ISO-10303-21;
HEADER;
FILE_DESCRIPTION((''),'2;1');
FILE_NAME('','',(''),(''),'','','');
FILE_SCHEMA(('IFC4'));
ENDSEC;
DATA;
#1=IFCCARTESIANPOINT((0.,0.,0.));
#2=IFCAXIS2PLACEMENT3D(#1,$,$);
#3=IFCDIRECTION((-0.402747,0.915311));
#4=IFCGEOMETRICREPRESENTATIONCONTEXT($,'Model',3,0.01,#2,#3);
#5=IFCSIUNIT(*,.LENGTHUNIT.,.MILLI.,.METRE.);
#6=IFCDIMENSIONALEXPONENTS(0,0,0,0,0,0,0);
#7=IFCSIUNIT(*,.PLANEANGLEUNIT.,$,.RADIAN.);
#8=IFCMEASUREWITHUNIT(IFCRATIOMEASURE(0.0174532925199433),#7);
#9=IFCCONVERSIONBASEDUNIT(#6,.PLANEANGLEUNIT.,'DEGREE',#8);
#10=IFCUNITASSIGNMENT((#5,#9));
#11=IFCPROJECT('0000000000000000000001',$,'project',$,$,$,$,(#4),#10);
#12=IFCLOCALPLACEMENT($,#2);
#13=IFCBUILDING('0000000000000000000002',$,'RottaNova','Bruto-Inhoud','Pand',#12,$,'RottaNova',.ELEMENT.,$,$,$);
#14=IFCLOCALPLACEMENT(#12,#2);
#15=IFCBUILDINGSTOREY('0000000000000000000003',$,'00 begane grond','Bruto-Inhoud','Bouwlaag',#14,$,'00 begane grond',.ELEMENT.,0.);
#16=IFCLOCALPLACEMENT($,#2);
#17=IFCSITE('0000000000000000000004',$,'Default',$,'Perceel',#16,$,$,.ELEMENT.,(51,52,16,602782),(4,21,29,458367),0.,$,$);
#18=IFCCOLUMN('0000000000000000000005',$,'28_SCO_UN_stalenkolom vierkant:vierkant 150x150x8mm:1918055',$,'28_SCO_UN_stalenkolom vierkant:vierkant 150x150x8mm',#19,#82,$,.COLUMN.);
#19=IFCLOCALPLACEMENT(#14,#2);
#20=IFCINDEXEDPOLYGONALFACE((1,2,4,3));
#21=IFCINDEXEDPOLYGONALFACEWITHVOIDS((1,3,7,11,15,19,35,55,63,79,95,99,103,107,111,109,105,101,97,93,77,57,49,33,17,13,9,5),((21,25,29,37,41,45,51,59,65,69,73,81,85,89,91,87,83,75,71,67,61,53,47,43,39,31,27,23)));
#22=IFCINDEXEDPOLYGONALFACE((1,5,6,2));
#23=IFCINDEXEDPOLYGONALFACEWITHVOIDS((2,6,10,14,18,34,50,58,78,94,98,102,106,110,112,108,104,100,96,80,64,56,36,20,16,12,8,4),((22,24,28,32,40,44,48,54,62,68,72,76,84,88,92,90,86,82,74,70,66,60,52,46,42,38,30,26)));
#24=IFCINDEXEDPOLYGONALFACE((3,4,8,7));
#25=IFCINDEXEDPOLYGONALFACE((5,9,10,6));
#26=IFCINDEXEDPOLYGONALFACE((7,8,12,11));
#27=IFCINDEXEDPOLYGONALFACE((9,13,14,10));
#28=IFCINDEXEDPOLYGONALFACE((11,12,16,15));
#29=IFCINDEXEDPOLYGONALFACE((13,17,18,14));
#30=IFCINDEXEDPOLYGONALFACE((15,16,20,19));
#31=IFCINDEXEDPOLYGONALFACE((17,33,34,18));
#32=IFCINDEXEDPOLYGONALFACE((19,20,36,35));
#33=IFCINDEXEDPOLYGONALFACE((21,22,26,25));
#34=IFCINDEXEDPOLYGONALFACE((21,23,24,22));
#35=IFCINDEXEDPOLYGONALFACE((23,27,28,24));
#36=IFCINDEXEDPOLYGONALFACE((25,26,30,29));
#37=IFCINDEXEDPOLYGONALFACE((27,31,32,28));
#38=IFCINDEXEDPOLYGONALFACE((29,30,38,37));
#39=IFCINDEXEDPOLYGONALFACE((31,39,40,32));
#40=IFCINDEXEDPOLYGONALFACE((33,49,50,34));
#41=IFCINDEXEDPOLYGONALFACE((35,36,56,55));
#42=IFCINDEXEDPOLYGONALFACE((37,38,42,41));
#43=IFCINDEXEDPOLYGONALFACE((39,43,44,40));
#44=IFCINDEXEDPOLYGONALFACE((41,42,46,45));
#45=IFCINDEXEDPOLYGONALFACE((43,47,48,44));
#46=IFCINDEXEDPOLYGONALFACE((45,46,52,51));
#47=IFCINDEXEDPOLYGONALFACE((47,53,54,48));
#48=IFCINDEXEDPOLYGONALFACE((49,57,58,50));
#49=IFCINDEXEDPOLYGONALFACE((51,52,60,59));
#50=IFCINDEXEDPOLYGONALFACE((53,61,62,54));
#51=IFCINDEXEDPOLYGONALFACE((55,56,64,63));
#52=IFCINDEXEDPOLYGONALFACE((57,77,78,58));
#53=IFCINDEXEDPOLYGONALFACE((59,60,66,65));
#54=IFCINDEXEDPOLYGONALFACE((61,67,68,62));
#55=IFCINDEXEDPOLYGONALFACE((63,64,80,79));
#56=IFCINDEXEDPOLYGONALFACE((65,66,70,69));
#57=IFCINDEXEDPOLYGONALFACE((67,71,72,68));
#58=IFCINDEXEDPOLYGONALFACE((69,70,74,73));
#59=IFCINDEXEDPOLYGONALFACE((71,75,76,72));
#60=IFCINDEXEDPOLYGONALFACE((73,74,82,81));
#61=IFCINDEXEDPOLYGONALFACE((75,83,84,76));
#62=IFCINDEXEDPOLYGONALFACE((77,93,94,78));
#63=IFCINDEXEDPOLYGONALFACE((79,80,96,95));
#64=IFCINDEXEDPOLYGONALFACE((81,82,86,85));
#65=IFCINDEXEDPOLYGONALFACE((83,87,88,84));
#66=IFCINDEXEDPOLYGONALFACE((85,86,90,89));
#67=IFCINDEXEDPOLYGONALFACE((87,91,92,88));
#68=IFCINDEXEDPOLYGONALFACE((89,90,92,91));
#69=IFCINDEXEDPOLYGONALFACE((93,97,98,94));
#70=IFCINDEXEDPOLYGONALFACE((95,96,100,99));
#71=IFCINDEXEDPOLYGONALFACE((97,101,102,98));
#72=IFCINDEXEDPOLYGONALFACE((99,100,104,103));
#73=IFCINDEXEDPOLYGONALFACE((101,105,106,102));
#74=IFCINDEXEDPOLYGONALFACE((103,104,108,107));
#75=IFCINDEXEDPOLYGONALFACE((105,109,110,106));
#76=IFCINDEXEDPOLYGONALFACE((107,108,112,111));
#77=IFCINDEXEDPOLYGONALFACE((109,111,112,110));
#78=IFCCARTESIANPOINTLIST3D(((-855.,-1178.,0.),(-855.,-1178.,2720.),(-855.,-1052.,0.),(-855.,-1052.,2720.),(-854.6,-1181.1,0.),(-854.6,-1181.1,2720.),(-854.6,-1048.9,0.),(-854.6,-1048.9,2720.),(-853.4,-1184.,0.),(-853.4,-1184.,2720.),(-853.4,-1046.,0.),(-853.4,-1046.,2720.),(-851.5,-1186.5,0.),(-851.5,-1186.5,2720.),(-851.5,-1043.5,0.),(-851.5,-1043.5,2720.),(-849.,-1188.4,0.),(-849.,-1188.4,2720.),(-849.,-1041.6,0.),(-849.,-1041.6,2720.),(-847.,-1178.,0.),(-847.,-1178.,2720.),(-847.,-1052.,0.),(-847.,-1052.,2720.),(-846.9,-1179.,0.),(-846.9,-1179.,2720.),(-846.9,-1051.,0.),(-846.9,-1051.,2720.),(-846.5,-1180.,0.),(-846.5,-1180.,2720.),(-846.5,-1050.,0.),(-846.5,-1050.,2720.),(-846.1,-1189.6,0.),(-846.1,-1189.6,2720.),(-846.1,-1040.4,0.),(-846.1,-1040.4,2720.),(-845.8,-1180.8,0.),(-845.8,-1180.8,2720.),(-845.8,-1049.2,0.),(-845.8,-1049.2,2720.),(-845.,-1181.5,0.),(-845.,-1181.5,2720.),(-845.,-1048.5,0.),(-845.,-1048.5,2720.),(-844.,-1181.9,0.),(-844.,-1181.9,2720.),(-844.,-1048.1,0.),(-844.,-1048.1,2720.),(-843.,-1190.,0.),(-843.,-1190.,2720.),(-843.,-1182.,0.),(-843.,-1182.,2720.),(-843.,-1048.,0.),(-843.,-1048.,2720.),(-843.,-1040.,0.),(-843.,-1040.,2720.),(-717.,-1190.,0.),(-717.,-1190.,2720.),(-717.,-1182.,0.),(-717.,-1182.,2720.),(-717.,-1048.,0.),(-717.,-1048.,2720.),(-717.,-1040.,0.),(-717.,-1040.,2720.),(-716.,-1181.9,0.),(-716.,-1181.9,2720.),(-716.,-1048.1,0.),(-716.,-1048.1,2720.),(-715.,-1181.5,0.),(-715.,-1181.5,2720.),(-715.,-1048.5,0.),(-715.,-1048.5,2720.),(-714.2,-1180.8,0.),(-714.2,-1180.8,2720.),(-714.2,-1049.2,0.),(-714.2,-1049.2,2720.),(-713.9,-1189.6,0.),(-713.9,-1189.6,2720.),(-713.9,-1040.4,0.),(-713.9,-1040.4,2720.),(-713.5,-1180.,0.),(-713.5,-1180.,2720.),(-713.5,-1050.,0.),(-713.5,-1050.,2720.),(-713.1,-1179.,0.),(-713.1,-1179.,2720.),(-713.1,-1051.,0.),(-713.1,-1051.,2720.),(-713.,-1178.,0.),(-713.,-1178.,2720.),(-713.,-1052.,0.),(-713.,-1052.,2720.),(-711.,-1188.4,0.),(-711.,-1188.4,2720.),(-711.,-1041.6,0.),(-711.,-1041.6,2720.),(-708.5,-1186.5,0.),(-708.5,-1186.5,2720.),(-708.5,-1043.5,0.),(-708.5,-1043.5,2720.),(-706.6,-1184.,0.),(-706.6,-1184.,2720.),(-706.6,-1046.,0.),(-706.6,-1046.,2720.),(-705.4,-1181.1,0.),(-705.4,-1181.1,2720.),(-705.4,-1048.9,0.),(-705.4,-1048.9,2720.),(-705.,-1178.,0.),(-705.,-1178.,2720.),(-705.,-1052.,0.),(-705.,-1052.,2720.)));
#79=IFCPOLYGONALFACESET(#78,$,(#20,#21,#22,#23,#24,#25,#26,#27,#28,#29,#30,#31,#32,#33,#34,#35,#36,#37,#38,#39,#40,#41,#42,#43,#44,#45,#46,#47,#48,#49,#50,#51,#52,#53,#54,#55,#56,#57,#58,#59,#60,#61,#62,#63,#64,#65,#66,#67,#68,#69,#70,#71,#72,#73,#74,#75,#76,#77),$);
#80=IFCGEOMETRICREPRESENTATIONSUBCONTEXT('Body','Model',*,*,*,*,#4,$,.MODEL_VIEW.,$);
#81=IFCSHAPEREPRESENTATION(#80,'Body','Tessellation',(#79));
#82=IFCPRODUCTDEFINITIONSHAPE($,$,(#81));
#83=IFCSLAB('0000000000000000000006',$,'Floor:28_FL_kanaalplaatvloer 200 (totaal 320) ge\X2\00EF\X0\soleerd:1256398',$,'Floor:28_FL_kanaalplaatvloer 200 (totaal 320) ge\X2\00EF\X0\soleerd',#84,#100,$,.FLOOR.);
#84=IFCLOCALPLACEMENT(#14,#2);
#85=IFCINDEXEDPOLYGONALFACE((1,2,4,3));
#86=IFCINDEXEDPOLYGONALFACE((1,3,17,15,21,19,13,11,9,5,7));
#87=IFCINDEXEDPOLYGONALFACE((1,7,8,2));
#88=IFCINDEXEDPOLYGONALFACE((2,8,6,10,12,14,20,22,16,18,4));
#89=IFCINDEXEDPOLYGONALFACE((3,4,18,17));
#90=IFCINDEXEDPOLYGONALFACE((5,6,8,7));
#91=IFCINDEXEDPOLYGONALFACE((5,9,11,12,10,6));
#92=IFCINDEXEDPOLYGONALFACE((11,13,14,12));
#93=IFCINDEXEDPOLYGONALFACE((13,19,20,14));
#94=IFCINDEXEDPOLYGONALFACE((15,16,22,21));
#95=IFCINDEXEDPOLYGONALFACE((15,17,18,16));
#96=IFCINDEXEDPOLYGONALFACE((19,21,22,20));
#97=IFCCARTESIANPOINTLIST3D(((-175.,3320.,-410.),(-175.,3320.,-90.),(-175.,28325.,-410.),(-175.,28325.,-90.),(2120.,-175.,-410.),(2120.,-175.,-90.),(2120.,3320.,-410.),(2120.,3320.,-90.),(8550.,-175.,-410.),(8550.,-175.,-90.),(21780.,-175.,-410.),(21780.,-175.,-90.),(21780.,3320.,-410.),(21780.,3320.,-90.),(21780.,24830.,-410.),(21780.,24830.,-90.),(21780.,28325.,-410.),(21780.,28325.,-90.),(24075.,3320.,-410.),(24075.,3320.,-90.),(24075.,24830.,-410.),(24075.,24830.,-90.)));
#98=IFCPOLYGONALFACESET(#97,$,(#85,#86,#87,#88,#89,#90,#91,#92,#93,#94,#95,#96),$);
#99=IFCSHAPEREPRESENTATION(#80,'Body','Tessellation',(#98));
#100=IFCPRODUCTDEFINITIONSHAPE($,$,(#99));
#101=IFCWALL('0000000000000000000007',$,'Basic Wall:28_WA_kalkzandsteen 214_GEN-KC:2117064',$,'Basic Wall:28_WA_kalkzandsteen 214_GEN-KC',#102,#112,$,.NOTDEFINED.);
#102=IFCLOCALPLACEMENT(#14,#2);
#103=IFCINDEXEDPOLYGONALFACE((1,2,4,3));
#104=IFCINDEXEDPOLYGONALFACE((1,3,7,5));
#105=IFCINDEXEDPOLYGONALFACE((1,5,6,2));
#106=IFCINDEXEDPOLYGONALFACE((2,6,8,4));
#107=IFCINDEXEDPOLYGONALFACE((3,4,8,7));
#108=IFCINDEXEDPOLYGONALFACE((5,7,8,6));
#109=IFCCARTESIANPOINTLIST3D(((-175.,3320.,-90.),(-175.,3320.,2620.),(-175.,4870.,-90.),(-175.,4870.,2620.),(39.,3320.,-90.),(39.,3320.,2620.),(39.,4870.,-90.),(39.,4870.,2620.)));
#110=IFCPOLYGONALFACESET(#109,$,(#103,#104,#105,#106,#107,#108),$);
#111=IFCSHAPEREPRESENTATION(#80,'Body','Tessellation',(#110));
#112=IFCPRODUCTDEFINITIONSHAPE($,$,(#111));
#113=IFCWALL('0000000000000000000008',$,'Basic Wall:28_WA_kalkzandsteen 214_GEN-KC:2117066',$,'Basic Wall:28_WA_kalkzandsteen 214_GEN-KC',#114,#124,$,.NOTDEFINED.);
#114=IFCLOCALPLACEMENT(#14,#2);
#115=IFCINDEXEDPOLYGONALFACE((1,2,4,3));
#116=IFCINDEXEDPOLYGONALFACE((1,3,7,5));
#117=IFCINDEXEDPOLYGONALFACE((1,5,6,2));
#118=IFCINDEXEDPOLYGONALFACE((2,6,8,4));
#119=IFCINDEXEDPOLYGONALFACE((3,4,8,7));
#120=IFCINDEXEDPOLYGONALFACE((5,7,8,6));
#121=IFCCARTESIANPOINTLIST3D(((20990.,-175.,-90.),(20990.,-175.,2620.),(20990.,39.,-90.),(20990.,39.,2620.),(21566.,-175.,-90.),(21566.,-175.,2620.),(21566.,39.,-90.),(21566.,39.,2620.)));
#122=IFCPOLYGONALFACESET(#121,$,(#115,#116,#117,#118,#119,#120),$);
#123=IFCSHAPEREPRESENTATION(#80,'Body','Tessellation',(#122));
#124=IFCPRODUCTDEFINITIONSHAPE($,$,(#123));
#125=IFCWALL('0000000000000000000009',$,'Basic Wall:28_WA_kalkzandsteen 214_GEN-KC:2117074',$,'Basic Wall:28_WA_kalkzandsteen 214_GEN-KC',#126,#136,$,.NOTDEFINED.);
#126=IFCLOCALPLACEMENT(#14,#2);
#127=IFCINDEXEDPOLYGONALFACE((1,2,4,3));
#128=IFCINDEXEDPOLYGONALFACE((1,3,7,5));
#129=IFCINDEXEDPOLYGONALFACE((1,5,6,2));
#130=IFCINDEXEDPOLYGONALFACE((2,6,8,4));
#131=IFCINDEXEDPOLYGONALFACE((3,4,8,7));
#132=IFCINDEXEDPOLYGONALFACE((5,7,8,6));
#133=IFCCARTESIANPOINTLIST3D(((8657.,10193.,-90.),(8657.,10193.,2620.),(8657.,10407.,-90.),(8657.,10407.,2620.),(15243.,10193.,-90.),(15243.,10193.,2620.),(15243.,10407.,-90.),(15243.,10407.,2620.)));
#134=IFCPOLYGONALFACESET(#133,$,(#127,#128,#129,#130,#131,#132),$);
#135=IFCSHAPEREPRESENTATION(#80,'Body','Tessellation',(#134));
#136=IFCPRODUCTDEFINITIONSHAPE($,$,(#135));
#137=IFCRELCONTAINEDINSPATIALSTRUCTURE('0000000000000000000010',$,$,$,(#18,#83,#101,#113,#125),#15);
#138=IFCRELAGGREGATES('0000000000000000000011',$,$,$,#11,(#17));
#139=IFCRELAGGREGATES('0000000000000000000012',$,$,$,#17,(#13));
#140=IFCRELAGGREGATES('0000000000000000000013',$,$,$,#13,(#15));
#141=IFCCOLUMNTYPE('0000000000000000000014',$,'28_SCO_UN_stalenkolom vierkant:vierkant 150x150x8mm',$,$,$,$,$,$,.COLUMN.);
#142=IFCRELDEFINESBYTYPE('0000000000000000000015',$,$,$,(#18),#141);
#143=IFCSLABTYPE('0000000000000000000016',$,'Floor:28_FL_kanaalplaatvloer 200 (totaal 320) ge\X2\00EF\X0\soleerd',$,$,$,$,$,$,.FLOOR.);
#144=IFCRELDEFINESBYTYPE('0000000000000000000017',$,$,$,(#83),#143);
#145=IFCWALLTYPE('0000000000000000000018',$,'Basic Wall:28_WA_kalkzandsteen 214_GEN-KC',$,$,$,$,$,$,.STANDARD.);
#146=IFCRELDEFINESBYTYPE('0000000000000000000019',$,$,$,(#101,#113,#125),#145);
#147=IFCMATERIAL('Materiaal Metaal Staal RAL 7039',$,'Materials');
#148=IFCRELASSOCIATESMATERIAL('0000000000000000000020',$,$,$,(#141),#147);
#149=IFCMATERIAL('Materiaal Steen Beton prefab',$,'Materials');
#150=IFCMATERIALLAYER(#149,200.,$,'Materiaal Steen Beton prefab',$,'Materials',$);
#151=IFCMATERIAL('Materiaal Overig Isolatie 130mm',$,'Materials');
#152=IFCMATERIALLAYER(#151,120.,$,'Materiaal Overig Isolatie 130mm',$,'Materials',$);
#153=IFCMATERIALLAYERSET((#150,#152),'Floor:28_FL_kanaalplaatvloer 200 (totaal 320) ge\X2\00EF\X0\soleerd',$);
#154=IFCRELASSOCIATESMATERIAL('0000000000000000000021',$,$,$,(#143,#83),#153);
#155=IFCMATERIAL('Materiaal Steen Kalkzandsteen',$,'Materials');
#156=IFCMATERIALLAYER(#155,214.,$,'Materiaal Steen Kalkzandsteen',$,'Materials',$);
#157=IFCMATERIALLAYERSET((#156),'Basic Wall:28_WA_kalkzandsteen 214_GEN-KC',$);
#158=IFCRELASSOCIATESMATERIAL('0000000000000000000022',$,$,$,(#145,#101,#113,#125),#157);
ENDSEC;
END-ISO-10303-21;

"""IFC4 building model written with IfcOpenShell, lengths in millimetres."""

from ifc_helpers import new_model, entity, si_unit, converted_unit, direction, frame, frame_2d, origin, place, context, subcontext, project, spatial, polyline, circle_curve, parameter, trimmed, segment, composite_curve, rectangle, outline, extrude, source, transform, mapped, material, layer, layer_set, layer_usage, material_profile, profile_set, type_object, type_shapes, element, save


model = new_model("IFC4")

# Units and contexts
model_context = context("Model", 3, precision=0.01, world=origin(), true_north=direction((-0.402747, 0.915311)))
body_context = subcontext(model_context, "Body", "Model", "MODEL_VIEW")
ifc_project = project(units=[si_unit("LENGTHUNIT", "METRE", prefix="MILLI"), converted_unit("PLANEANGLEUNIT", "DEGREE", entity("IfcRatioMeasure", 0.0174532925199433), si_unit("PLANEANGLEUNIT", "RADIAN"), dimensions=[0, 0, 0, 0, 0, 0, 0])], contexts=[model_context])

# Site, building, storey
site_placement = place(None, origin())
site = spatial("IfcSite", under=ifc_project, at=site_placement, Name="Default", ObjectType="Perceel", CompositionType="ELEMENT", RefLatitude=(51, 52, 16, 602782), RefLongitude=(4, 21, 29, 458367), RefElevation=0.0)
building_placement = place(None, origin())
building = spatial("IfcBuilding", under=site, at=building_placement, Name="RottaNova", Description="Bruto-Inhoud", ObjectType="Pand", LongName="RottaNova", CompositionType="ELEMENT")
storey_placement = place(building_placement, origin())
storey = spatial("IfcBuildingStorey", under=building, at=storey_placement, Name="00 begane grond", Description="Bruto-Inhoud", ObjectType="Bouwlaag", LongName="00 begane grond", CompositionType="ELEMENT", Elevation=0.0)

# Column
ifc_material_1 = material(Name="Materiaal Metaal Staal RAL 7039", Category="Materials")
ifc_material_profile = material_profile(ifc_material_1, outline(composite_curve([segment(trimmed(circle_curve(frame_2d((63.0, -63.0), x_axis=(1.0, 0.0)), 12.0), [parameter(270.0)], [parameter(360.0)], True, "PARAMETER"), True, "CONTINUOUS"), segment(polyline([(75.0, -63.0), (75.0, 63.0)]), True, "CONTINUOUS"), segment(trimmed(circle_curve(frame_2d((63.0, 63.0), x_axis=(1.0, 0.0)), 12.0), [parameter(360.0)], [parameter(90.0)], True, "PARAMETER"), True, "CONTINUOUS"), segment(polyline([(63.0, 75.0), (-63.0, 75.0)]), True, "CONTINUOUS"), segment(trimmed(circle_curve(frame_2d((-63.0, 63.0), x_axis=(1.0, 0.0)), 12.0), [parameter(90.0)], [parameter(180.0)], True, "PARAMETER"), True, "CONTINUOUS"), segment(polyline([(-75.0, 63.0), (-75.0, -63.0)]), True, "CONTINUOUS"), segment(trimmed(circle_curve(frame_2d((-63.0, -63.0), x_axis=(1.0, 0.0)), 12.0), [parameter(180.0)], [parameter(270.0)], True, "PARAMETER"), True, "CONTINUOUS"), segment(polyline([(-63.0, -75.0), (63.0, -75.0)]), True, "CONTINUOUS")], self_intersect=False), holes=[composite_curve([segment(polyline([(-67.0, -63.0), (-67.0, 63.0)]), True, "CONTINUOUS"), segment(trimmed(circle_curve(frame_2d((-63.0, 63.0), x_axis=(1.0, 0.0)), 4.0), [parameter(90.0)], [parameter(180.0)], True, "PARAMETER"), False, "CONTINUOUS"), segment(polyline([(-63.0, 67.0), (63.0, 67.0)]), True, "CONTINUOUS"), segment(trimmed(circle_curve(frame_2d((63.0, 63.0), x_axis=(1.0, 0.0)), 4.0), [parameter(0.0)], [parameter(90.0)], True, "PARAMETER"), False, "CONTINUOUS"), segment(polyline([(67.0, 63.0), (67.0, -63.0)]), True, "CONTINUOUS"), segment(trimmed(circle_curve(frame_2d((63.0, -63.0), x_axis=(1.0, 0.0)), 4.0), [parameter(270.0)], [parameter(0.0)], True, "PARAMETER"), False, "CONTINUOUS"), segment(polyline([(63.0, -67.0), (-63.0, -67.0)]), True, "CONTINUOUS"), segment(trimmed(circle_curve(frame_2d((-63.0, -63.0), x_axis=(1.0, 0.0)), 4.0), [parameter(180.0)], [parameter(270.0)], True, "PARAMETER"), False, "CONTINUOUS")], self_intersect=False)]), Name="vierkant 150x150x8mm")
ifc_profile_set = profile_set([ifc_material_profile], Name="vierkant 150x150x8mm")
column_type_1 = type_object("IfcColumnType", Name="28_SCO_UN_stalenkolom vierkant:vierkant 150x150x8mm", PredefinedType="COLUMN", material=ifc_profile_set)
shared_shape_1 = source(origin(), body_context, "Body", "SweptSolid", [
    extrude(outline(composite_curve([segment(polyline([(-63.0, -75.0), (63.0, -75.0)]), True, "CONTINUOUS"), segment(trimmed(circle_curve(frame_2d((63.0, -63.0), x_axis=(-1.0, 0.0)), 12.0), [parameter(90.0)], [parameter(180.0)], True, "PARAMETER"), True, "CONTINUOUS"), segment(polyline([(75.0, -63.0), (75.0, 63.0)]), True, "CONTINUOUS"), segment(trimmed(circle_curve(frame_2d((63.0, 63.0), x_axis=(-1.0, 0.0)), 12.0), [parameter(180.0)], [parameter(270.0)], True, "PARAMETER"), True, "CONTINUOUS"), segment(polyline([(63.0, 75.0), (-63.0, 75.0)]), True, "CONTINUOUS"), segment(trimmed(circle_curve(frame_2d((-63.0, 63.0), x_axis=(-1.0, 0.0)), 12.0), [parameter(270.0)], [parameter(0.0)], True, "PARAMETER"), True, "CONTINUOUS"), segment(polyline([(-75.0, 63.0), (-75.0, -63.0)]), True, "CONTINUOUS"), segment(trimmed(circle_curve(frame_2d((-63.0, -63.0), x_axis=(-1.0, 0.0)), 12.0), [parameter(0.0)], [parameter(90.0)], True, "PARAMETER"), True, "CONTINUOUS")], self_intersect=False), holes=[composite_curve([segment(trimmed(circle_curve(frame_2d((63.0, -63.0), x_axis=(-1.0, 0.0)), 4.0), [parameter(90.0)], [parameter(180.0)], True, "PARAMETER"), False, "CONTINUOUS"), segment(polyline([(63.0, -67.0), (-63.0, -67.0)]), True, "CONTINUOUS"), segment(trimmed(circle_curve(frame_2d((-63.0, -63.0), x_axis=(-1.0, 0.0)), 4.0), [parameter(0.0)], [parameter(90.0)], True, "PARAMETER"), False, "CONTINUOUS"), segment(polyline([(-67.0, -63.0), (-67.0, 63.0)]), True, "CONTINUOUS"), segment(trimmed(circle_curve(frame_2d((-63.0, 63.0), x_axis=(-1.0, 0.0)), 4.0), [parameter(270.0)], [parameter(360.0)], True, "PARAMETER"), False, "CONTINUOUS"), segment(polyline([(-63.0, 67.0), (63.0, 67.0)]), True, "CONTINUOUS"), segment(trimmed(circle_curve(frame_2d((63.0, 63.0), x_axis=(-1.0, 0.0)), 4.0), [parameter(180.0)], [parameter(270.0)], True, "PARAMETER"), False, "CONTINUOUS"), segment(polyline([(67.0, 63.0), (67.0, -63.0)]), True, "CONTINUOUS")], self_intersect=False)]), frame((0.0, 0.0, 0.0), z_axis=(0.0, 0.0, 1.0), x_axis=(-1.0, 0.0, 0.0)), (0.0, 0.0, 1.0), 2720.0),
])
type_shapes(column_type_1, [shared_shape_1])
column_1_placement = place(storey_placement, frame((-780.0, -1115.0, 0.0), z_axis=(0.0, 0.0, 1.0), x_axis=(-1.0, 0.0, 0.0)))
element("IfcColumn", 1, at=column_1_placement, inside=storey, type_object=column_type_1, Name="28_SCO_UN_stalenkolom vierkant:vierkant 150x150x8mm:1918055", ObjectType="28_SCO_UN_stalenkolom vierkant:vierkant 150x150x8mm", PredefinedType="COLUMN", context=body_context, shape_type="MappedRepresentation", body=[
    mapped(shared_shape_1, transform((0.0, 0.0, 0.0), scale=1.0)),
])

# Slab
ifc_material_2 = material(Name="Materiaal Steen Beton prefab", Category="Materials")
ifc_layer_1 = layer(ifc_material_2, 200.0, Name="Materiaal Steen Beton prefab", Category="Materials")
ifc_material_3 = material(Name="Materiaal Overig Isolatie 130mm", Category="Materials")
ifc_layer_2 = layer(ifc_material_3, 120.0, Name="Materiaal Overig Isolatie 130mm", Category="Materials")
ifc_layer_set_1 = layer_set([ifc_layer_1, ifc_layer_2], Name="Floor:28_FL_kanaalplaatvloer 200 (totaal 320) geïsoleerd")
ifc_layer_usage = layer_usage(ifc_layer_set_1, "AXIS3", "POSITIVE", 0.0)
slab_type = type_object("IfcSlabType", Name="Floor:28_FL_kanaalplaatvloer 200 (totaal 320) geïsoleerd", PredefinedType="FLOOR", material=ifc_layer_set_1)
slab_placement = place(storey_placement, frame((-175.0, -175.0, -410.0)))
element("IfcSlab", 2, at=slab_placement, inside=storey, type_object=slab_type, material=ifc_layer_usage, Name="Floor:28_FL_kanaalplaatvloer 200 (totaal 320) geïsoleerd:1256398", ObjectType="Floor:28_FL_kanaalplaatvloer 200 (totaal 320) geïsoleerd", PredefinedType="FLOOR", context=body_context, shape_type="SweptSolid", body=[
    extrude(outline(polyline([(-9830.0, 14250.0), (-9830.0, 10755.0), (-12125.0, 10755.0), (-12125.0, -10755.0), (-9830.0, -10755.0), (-9830.0, -14250.0), (3400.0, -14250.0), (9830.0, -14250.0), (9830.0, -10755.0), (12125.0, -10755.0), (12125.0, 14250.0), (-9830.0, 14250.0)])), frame((12125.0, 14250.0, 320.0), z_axis=(0.0, 0.0, -1.0), x_axis=(-1.0, 0.0, 0.0)), (0.0, 0.0, 1.0), 320.0),
])

# Walls
ifc_material_4 = material(Name="Materiaal Steen Kalkzandsteen", Category="Materials")
ifc_layer_3 = layer(ifc_material_4, 214.0, Name="Materiaal Steen Kalkzandsteen", Category="Materials")
ifc_layer_set_2 = layer_set([ifc_layer_3], Name="Basic Wall:28_WA_kalkzandsteen 214_GEN-KC")
wall_type = type_object("IfcWallType", Name="Basic Wall:28_WA_kalkzandsteen 214_GEN-KC", PredefinedType="STANDARD", material=ifc_layer_set_2)
wall_1_placement = place(storey_placement, frame((-68.0, 3320.0, -90.0), z_axis=(0.0, 0.0, 1.0), x_axis=(0.0, 1.0, 0.0)))
element("IfcWall", 3, at=wall_1_placement, inside=storey, type_object=wall_type, material=ifc_layer_set_2, Name="Basic Wall:28_WA_kalkzandsteen 214_GEN-KC:2117064", ObjectType="Basic Wall:28_WA_kalkzandsteen 214_GEN-KC", PredefinedType="NOTDEFINED", context=body_context, shape_type="SweptSolid", body=[
    extrude(rectangle(XDim=1550.0, YDim=214.0, at=frame_2d((775.0, 0.0), x_axis=(-1.0, 0.0))), origin(), (0.0, 0.0, 1.0), 2710.0),
])
wall_2_placement = place(storey_placement, frame((21566.0, -68.0, -90.0), z_axis=(0.0, 0.0, 1.0), x_axis=(-1.0, 0.0, 0.0)))
element("IfcWall", 4, at=wall_2_placement, inside=storey, type_object=wall_type, material=ifc_layer_set_2, Name="Basic Wall:28_WA_kalkzandsteen 214_GEN-KC:2117066", ObjectType="Basic Wall:28_WA_kalkzandsteen 214_GEN-KC", PredefinedType="NOTDEFINED", context=body_context, shape_type="SweptSolid", body=[
    extrude(rectangle(XDim=576.0, YDim=214.0, at=frame_2d((288.0, 0.0), x_axis=(-1.0, 0.0))), origin(), (0.0, 0.0, 1.0), 2710.0),
])
wall_3_placement = place(storey_placement, frame((8657.0, 10300.0, -90.0)))
element("IfcWall", 5, at=wall_3_placement, inside=storey, type_object=wall_type, material=ifc_layer_set_2, Name="Basic Wall:28_WA_kalkzandsteen 214_GEN-KC:2117074", ObjectType="Basic Wall:28_WA_kalkzandsteen 214_GEN-KC", PredefinedType="NOTDEFINED", context=body_context, shape_type="SweptSolid", body=[
    extrude(rectangle(XDim=6586.0, YDim=214.0, at=frame_2d((3293.0, 0.0), x_axis=(-1.0, 0.0))), origin(), (0.0, 0.0, 1.0), 2710.0),
])

save(model, "model.ifc")
